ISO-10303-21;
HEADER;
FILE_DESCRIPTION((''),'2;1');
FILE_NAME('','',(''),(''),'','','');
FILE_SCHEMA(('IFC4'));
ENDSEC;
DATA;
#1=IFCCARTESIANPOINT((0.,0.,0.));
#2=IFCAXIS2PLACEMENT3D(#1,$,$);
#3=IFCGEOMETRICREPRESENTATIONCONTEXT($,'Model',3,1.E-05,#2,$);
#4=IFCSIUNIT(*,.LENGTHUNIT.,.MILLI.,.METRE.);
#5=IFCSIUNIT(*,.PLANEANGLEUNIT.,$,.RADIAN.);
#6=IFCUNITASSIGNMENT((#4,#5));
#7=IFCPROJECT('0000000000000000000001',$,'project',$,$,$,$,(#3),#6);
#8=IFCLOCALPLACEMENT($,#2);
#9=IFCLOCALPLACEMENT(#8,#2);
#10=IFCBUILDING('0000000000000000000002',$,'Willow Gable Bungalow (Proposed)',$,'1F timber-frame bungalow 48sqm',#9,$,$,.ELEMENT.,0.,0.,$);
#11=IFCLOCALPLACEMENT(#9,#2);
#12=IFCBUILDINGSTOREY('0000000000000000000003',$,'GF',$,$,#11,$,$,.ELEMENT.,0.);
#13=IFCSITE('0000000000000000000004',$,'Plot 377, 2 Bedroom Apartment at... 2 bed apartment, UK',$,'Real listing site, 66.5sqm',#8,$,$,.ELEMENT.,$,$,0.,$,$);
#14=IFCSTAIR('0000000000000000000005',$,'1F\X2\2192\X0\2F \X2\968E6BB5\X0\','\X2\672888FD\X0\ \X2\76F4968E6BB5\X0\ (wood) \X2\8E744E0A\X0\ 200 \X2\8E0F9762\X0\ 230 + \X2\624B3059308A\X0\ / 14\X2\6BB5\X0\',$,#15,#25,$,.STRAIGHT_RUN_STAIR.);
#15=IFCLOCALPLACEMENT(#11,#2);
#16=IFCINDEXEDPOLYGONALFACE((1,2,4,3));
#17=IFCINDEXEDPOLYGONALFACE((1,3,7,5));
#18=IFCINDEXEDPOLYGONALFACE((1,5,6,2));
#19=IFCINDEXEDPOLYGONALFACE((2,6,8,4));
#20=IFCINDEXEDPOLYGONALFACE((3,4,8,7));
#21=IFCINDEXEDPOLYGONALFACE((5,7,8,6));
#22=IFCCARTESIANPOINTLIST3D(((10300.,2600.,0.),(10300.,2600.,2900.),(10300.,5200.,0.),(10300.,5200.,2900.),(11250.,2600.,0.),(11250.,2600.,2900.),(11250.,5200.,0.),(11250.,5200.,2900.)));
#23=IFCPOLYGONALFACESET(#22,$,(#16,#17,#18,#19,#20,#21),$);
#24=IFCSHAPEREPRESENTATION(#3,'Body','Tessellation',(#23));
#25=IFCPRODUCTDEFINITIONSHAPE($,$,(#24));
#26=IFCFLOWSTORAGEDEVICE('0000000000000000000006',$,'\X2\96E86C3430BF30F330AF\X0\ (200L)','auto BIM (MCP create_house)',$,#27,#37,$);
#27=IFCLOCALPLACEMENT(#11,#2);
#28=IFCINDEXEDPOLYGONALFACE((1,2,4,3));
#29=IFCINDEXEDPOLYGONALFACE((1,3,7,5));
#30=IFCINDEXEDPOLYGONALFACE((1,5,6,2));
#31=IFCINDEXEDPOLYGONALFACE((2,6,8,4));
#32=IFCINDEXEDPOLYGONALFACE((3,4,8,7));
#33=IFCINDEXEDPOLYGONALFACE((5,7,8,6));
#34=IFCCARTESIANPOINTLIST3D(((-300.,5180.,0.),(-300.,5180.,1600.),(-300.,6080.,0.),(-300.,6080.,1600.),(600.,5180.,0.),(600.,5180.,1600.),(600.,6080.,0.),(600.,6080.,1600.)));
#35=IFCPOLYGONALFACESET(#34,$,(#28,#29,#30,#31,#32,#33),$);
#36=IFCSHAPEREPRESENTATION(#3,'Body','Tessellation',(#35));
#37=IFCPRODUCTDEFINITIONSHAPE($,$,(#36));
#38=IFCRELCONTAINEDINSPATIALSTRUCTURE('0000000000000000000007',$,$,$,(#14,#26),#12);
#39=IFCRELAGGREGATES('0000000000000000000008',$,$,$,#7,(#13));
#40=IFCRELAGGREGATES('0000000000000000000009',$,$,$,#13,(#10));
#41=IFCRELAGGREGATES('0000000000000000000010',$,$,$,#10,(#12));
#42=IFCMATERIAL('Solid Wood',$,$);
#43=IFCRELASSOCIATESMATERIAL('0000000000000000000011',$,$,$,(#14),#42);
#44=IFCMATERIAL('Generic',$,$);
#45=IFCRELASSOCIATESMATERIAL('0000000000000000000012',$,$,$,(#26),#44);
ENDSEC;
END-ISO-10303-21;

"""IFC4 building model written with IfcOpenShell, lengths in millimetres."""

from ifc_helpers import new_model, si_unit, frame, frame_2d, origin, place, context, project, spatial, rectangle, extrude, material, element, save


model = new_model("IFC4")

# Units and contexts
model_context = context("Model", 3, precision=1e-05, world=origin())
ifc_project = project(units=[si_unit("LENGTHUNIT", "METRE", prefix="MILLI"), si_unit("PLANEANGLEUNIT", "RADIAN")], contexts=[model_context])

# Site, building, storey
site_placement = place(None, origin())
site = spatial("IfcSite", under=ifc_project, at=site_placement, Name="Plot 377, 2 Bedroom Apartment at... 2 bed apartment, UK", ObjectType="Real listing site, 66.5sqm", CompositionType="ELEMENT", RefElevation=0.0)
building_placement = place(site_placement, origin())
building = spatial("IfcBuilding", under=site, at=building_placement, Name="Willow Gable Bungalow (Proposed)", ObjectType="1F timber-frame bungalow 48sqm", CompositionType="ELEMENT", ElevationOfRefHeight=0.0, ElevationOfTerrain=0.0)
storey_placement = place(building_placement, origin())
storey = spatial("IfcBuildingStorey", under=building, at=storey_placement, Name="GF", CompositionType="ELEMENT", Elevation=0.0)

# Shared definitions
ifc_material_1 = material(Name="Solid Wood")
ifc_material_2 = material(Name="Generic")

# Stair
stair_placement = place(storey_placement, frame((5150.0, 1300.0, 0.0)))
element("IfcStair", 1, at=stair_placement, inside=storey, material=ifc_material_1, Name="1F→2F 階段", Description="木製 直階段 (wood) 蹴上 200 踏面 230 + 手すり / 14段", PredefinedType="STRAIGHT_RUN_STAIR", context=model_context, shape_type="SweptSolid", body=[
    extrude(rectangle(XDim=950.0, YDim=2600.0, at=frame_2d((475.0, 1300.0))), frame((5150.0, 1300.0, 0.0)), (0.0, 0.0, 1.0), 2900.0),
])

# Flow storage device
flow_storage_device_placement = place(storey_placement, frame((-150.0, 2590.0, 0.0)))
element("IfcFlowStorageDevice", 2, at=flow_storage_device_placement, inside=storey, material=ifc_material_2, Name="雨水タンク (200L)", Description="auto BIM (MCP create_house)", context=model_context, shape_type="SweptSolid", body=[
    extrude(rectangle(XDim=900.0, YDim=900.0, at=frame_2d((450.0, 450.0))), frame((-150.0, 2590.0, 0.0)), (0.0, 0.0, 1.0), 1600.0),
])

save(model, "model.ifc")
